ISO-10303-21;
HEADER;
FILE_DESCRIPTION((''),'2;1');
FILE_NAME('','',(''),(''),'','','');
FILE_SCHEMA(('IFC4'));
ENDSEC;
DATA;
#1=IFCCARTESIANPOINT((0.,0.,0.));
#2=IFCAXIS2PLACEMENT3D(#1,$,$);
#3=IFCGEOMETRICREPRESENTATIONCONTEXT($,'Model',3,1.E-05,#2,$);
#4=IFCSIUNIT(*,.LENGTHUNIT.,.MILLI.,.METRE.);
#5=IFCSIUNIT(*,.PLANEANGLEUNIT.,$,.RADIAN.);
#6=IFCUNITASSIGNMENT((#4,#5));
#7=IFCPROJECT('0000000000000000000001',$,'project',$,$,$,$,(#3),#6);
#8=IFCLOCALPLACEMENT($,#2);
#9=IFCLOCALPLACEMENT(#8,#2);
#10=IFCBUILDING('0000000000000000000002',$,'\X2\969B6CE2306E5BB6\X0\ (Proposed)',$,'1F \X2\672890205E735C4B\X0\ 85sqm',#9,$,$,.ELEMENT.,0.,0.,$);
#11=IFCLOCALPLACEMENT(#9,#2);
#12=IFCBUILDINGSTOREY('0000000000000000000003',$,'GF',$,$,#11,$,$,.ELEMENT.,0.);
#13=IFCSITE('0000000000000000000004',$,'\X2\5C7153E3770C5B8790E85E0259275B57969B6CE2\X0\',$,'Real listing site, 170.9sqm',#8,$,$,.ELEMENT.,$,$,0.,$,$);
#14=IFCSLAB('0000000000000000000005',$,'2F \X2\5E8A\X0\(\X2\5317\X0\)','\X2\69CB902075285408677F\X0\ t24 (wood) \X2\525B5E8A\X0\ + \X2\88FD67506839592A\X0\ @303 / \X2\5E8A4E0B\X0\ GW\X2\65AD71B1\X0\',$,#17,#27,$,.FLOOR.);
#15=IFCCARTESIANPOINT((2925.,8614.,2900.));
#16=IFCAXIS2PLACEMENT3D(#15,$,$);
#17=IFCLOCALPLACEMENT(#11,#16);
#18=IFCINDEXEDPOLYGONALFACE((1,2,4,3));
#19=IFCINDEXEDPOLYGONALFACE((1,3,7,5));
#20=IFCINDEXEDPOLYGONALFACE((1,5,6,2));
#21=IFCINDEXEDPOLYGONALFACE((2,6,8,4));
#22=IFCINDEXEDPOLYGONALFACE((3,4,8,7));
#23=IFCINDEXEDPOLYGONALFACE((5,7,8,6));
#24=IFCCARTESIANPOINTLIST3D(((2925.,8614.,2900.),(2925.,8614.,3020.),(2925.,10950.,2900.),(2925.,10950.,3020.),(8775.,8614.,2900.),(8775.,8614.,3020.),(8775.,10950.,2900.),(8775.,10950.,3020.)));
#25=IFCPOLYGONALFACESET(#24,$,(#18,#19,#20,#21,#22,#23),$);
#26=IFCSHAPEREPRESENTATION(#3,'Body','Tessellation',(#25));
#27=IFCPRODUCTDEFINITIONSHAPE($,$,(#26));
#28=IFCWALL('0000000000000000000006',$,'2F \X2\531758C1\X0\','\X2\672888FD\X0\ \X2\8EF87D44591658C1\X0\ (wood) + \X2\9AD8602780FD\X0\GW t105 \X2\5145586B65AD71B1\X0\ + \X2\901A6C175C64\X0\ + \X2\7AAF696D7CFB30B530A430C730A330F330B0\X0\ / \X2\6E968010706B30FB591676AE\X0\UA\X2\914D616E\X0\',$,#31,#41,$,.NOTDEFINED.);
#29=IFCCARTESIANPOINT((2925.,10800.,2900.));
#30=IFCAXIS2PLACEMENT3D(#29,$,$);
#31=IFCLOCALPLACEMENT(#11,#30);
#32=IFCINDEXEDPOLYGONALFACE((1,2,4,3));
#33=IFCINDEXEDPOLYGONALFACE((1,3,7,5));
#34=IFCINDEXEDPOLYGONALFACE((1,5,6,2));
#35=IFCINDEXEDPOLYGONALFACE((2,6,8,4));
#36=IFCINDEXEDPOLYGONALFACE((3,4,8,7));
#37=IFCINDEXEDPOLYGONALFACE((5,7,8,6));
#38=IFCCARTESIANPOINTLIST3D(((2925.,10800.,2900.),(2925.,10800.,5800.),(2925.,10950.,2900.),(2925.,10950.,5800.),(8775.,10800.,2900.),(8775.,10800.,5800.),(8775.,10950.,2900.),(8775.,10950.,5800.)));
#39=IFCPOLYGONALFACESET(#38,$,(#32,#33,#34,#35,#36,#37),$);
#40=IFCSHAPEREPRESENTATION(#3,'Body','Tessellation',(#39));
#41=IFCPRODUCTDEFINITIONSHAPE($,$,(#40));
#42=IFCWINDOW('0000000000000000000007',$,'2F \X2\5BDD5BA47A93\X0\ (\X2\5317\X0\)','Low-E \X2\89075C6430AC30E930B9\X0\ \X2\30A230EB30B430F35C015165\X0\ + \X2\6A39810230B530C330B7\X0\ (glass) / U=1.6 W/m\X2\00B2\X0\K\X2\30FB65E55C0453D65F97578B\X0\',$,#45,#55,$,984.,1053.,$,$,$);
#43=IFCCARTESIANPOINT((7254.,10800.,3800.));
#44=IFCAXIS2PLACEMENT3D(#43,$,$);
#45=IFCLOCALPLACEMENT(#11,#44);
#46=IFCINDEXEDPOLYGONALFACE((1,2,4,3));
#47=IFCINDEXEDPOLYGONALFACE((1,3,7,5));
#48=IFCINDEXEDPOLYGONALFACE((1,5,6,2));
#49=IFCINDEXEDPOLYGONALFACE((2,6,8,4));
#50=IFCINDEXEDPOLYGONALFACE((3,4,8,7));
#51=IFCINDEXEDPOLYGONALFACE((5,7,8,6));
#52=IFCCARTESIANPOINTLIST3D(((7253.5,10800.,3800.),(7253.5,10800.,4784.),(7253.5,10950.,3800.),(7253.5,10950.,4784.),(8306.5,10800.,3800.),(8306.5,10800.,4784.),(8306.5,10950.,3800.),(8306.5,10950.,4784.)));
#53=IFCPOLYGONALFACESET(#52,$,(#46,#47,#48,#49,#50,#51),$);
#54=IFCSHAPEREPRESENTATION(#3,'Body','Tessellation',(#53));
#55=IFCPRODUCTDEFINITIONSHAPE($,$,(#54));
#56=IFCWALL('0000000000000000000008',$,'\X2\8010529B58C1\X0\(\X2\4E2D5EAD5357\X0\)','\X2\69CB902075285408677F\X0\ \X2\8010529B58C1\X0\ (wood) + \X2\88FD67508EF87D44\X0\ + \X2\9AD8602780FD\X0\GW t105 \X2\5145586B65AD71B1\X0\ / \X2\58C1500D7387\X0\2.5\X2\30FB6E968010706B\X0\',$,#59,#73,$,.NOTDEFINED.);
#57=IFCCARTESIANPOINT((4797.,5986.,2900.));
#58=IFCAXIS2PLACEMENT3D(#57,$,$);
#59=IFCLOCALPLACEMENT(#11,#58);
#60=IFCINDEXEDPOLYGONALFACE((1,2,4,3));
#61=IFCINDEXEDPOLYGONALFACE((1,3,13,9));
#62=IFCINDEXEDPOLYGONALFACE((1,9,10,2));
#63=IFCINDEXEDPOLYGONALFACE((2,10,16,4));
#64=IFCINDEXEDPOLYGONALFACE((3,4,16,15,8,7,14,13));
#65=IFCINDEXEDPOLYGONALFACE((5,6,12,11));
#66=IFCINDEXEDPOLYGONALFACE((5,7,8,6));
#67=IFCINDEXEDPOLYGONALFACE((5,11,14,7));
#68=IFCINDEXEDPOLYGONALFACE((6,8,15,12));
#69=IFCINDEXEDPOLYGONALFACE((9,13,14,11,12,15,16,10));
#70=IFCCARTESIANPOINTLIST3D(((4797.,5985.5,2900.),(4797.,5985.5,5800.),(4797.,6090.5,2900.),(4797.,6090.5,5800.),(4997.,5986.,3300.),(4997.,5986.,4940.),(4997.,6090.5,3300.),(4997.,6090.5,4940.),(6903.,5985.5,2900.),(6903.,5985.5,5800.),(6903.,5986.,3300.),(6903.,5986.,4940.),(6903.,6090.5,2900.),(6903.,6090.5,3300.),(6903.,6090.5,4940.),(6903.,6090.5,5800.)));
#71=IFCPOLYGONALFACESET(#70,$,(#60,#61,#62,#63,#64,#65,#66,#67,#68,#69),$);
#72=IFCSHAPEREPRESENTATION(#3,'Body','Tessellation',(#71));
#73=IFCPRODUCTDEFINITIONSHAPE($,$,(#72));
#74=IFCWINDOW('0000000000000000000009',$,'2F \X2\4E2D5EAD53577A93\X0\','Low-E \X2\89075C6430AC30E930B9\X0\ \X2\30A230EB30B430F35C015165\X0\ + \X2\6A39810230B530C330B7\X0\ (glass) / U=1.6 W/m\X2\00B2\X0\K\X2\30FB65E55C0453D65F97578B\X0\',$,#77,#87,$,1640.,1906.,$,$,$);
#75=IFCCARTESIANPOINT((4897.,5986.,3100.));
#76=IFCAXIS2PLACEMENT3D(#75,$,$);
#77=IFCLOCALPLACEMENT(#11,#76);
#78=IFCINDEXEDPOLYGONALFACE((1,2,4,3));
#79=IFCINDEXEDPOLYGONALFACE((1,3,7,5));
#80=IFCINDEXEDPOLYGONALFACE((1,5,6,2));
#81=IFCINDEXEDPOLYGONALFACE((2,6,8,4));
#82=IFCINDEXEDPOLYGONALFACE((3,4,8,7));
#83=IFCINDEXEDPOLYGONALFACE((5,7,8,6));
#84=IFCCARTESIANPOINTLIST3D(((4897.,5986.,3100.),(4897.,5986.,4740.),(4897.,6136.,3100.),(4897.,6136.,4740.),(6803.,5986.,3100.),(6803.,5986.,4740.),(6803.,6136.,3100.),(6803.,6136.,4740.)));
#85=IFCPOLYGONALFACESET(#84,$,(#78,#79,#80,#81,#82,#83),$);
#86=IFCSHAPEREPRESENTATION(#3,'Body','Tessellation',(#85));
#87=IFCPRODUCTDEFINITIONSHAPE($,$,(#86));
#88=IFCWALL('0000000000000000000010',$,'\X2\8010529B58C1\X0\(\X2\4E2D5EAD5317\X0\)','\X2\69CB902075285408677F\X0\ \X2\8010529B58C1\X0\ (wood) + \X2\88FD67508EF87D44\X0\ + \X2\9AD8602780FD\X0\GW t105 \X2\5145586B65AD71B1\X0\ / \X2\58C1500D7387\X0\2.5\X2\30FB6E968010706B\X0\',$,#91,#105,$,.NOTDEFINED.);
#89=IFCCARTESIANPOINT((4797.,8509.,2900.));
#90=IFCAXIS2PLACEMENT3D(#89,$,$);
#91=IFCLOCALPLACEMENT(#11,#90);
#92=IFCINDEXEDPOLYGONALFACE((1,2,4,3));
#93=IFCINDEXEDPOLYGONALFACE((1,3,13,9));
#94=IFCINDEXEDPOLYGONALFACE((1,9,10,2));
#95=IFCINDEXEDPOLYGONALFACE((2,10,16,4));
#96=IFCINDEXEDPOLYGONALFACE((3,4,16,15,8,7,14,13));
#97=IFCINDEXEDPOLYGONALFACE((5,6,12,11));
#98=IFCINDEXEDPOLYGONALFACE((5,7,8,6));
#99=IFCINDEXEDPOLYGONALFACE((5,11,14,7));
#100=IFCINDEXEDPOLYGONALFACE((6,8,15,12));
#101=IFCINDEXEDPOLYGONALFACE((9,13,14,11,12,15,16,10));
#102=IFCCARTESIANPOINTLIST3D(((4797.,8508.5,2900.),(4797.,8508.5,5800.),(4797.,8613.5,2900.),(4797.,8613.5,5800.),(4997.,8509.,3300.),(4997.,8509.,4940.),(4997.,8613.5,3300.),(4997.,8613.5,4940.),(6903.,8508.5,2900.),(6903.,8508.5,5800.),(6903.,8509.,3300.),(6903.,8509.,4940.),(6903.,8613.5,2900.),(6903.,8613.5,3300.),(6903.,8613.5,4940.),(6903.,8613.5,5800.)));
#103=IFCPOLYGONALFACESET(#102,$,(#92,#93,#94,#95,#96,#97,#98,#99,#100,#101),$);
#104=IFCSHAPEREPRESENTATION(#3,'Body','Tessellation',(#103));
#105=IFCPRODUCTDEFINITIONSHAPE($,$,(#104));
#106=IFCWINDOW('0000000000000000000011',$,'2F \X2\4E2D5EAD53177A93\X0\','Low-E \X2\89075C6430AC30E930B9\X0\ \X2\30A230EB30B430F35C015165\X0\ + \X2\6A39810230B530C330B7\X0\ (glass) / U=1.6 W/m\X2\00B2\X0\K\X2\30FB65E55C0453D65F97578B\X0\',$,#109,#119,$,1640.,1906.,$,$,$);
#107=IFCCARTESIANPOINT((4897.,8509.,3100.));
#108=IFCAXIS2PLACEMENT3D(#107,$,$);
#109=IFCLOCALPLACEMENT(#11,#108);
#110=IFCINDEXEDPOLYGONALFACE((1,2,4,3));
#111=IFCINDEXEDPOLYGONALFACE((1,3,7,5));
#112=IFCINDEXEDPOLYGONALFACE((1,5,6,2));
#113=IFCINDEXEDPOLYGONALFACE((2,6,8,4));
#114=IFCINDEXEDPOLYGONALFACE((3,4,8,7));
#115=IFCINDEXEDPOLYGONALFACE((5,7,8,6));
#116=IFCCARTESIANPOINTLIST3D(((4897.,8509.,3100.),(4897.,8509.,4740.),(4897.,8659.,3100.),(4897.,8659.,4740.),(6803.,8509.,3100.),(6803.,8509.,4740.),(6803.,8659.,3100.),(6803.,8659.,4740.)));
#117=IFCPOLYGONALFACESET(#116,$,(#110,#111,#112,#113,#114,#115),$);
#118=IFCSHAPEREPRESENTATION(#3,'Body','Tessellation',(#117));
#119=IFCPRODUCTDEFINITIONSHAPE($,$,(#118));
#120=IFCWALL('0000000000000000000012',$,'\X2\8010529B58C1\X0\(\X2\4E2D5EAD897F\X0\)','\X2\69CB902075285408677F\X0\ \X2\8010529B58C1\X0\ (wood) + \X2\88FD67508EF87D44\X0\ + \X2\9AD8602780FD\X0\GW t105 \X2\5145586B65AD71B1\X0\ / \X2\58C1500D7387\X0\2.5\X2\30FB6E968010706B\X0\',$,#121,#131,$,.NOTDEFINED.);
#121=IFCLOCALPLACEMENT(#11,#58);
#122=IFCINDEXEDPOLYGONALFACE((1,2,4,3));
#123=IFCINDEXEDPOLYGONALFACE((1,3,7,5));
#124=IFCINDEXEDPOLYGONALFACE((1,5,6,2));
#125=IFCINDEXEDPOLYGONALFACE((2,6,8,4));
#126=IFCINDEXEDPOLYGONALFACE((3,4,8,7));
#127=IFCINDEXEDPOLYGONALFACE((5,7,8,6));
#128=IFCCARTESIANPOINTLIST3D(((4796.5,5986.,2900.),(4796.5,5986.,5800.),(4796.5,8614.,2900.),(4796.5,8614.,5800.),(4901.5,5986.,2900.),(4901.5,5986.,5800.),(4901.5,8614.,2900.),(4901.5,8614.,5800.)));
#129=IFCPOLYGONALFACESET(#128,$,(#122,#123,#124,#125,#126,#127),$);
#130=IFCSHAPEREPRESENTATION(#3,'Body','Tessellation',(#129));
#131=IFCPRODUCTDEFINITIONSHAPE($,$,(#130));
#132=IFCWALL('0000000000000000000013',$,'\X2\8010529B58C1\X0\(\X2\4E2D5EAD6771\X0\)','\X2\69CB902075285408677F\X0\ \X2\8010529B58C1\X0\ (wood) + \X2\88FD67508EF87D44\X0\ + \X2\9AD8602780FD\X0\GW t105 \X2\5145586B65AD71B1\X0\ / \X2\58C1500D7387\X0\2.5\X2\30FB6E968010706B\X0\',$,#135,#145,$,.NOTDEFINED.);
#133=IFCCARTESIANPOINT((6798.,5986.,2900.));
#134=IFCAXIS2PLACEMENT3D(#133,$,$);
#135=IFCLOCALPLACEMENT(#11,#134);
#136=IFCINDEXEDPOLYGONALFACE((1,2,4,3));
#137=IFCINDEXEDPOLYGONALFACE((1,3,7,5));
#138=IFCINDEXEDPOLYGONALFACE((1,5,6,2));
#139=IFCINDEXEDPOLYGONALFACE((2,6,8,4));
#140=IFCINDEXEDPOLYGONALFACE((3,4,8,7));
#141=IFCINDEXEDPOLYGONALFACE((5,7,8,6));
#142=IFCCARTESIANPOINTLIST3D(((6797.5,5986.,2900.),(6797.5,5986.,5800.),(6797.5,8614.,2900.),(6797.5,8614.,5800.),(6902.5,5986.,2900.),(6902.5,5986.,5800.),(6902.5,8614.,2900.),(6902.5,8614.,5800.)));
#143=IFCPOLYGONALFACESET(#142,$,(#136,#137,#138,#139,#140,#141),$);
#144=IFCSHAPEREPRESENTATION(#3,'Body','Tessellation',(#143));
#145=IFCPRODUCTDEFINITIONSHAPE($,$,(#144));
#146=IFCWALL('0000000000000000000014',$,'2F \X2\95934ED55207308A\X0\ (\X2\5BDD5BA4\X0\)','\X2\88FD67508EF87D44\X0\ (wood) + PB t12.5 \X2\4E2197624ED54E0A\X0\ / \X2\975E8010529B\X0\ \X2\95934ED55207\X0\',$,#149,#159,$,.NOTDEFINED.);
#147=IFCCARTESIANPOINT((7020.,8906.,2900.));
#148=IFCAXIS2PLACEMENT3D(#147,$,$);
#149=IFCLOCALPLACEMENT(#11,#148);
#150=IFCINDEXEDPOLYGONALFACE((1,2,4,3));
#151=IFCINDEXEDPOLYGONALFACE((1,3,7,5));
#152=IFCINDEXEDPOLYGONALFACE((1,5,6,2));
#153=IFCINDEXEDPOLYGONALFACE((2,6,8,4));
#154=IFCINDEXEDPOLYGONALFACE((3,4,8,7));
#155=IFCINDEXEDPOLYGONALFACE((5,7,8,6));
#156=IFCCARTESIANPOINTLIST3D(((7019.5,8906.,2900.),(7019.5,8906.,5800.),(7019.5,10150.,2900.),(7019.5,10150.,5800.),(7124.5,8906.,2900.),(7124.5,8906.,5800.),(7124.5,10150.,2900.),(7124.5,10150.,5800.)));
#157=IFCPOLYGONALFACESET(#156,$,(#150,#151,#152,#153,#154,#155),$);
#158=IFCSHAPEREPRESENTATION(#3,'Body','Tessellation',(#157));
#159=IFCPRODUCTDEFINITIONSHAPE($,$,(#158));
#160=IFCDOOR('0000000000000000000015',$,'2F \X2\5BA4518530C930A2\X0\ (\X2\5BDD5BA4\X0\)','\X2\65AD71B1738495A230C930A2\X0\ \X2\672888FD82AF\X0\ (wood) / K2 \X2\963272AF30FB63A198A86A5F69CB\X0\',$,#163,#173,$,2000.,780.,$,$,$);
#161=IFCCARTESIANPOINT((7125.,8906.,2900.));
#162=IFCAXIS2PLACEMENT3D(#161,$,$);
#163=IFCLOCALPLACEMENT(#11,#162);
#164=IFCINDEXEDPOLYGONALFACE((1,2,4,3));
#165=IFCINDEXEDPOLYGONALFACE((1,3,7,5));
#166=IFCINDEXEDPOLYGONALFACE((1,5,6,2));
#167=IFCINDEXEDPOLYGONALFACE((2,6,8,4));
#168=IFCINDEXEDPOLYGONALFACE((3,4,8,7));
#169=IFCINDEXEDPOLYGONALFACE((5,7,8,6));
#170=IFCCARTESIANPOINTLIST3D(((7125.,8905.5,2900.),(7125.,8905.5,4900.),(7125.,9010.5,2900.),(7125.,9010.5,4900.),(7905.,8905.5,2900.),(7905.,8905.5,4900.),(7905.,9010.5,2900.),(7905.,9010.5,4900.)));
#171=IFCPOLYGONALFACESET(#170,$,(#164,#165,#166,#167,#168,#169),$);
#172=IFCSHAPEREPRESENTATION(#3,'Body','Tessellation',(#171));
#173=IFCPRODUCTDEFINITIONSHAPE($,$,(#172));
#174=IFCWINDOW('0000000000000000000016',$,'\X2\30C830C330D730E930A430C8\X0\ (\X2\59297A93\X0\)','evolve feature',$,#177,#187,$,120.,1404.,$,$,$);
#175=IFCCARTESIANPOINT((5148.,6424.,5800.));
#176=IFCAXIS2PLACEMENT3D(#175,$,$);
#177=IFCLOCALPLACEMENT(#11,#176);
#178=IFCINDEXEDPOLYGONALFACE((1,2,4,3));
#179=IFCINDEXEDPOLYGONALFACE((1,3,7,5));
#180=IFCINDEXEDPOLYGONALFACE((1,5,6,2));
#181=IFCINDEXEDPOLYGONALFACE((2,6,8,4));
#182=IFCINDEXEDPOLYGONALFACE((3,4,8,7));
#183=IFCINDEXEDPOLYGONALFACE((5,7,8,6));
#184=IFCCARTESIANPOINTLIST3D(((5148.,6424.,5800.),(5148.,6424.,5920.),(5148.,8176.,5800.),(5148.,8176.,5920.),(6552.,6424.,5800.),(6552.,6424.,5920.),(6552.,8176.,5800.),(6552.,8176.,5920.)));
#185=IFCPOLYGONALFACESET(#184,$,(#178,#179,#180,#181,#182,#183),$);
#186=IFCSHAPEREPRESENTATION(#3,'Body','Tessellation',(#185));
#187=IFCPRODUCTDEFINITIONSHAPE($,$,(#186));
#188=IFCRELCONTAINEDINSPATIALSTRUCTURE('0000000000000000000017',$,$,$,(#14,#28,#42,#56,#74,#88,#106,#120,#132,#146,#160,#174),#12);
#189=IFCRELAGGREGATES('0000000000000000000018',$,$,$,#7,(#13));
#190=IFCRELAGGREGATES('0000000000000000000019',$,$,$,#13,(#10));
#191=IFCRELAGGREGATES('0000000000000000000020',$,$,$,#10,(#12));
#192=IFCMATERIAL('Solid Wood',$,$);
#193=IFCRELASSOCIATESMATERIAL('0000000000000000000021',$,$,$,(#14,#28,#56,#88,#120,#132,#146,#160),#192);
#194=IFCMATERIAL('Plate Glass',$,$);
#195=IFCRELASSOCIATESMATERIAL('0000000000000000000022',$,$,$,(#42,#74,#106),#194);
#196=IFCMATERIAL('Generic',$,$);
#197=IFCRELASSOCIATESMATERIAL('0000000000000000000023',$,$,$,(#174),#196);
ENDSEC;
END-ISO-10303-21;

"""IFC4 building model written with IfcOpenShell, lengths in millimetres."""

from ifc_helpers import new_model, si_unit, frame, frame_2d, origin, place, context, project, spatial, rectangle, extrude, material, element, fill, save


model = new_model("IFC4")

# Units and contexts
model_context = context("Model", 3, precision=1e-05, world=origin())
ifc_project = project(units=[si_unit("LENGTHUNIT", "METRE", prefix="MILLI"), si_unit("PLANEANGLEUNIT", "RADIAN")], contexts=[model_context])

# Site, building, storey
site_placement = place(None, origin())
site = spatial("IfcSite", under=ifc_project, at=site_placement, Name="山口県宇部市大字際波", ObjectType="Real listing site, 170.9sqm", CompositionType="ELEMENT", RefElevation=0.0)
building_placement = place(site_placement, origin())
building = spatial("IfcBuilding", under=site, at=building_placement, Name="際波の家 (Proposed)", ObjectType="1F 木造平屋 85sqm", CompositionType="ELEMENT", ElevationOfRefHeight=0.0, ElevationOfTerrain=0.0)
storey_placement = place(building_placement, origin())
storey = spatial("IfcBuildingStorey", under=building, at=storey_placement, Name="GF", CompositionType="ELEMENT", Elevation=0.0)

# Slab
ifc_material_1 = material(Name="Solid Wood")
slab_placement = place(storey_placement, frame((2925.0, 8614.0, 2900.0)))
element("IfcSlab", 1, at=slab_placement, inside=storey, material=ifc_material_1, Name="2F 床(北)", Description="構造用合板 t24 (wood) 剛床 + 製材根太 @303 / 床下 GW断熱", PredefinedType="FLOOR", context=model_context, shape_type="SweptSolid", body=[
    extrude(rectangle(XDim=5850.0, YDim=2336.0, at=frame_2d((2925.0, 1168.0))), frame((2925.0, 8614.0, 2900.0)), (0.0, 0.0, 1.0), 120.0),
])

# Walls, openings, windows
wall_1_placement = place(storey_placement, frame((2925.0, 10800.0, 2900.0)))
wall_1 = element("IfcWall", 2, at=wall_1_placement, inside=storey, material=ifc_material_1, Name="2F 北壁", Description="木製 軸組外壁 (wood) + 高性能GW t105 充填断熱 + 通気層 + 窯業系サイディング / 準耐火・外皮UA配慮", PredefinedType="NOTDEFINED", context=model_context, shape_type="SweptSolid", body=[
    extrude(rectangle(XDim=5850.0, YDim=150.0, at=frame_2d((2925.0, 75.0))), frame((2925.0, 10800.0, 2900.0)), (0.0, 0.0, 1.0), 2900.0),
])
opening_1_placement = place(storey_placement, frame((7254.0, 10800.0, 3800.0)))
opening_1 = element("IfcOpeningElement", 3, at=opening_1_placement, cuts=wall_1, PredefinedType="NOTDEFINED", context=model_context, shape_type="SweptSolid", body=[
    extrude(rectangle(XDim=1053.0, YDim=150.0, at=frame_2d((526.0, 75.0))), frame((7254.0, 10800.0, 3800.0)), (0.0, 0.0, 1.0), 984.0),
])
ifc_material_2 = material(Name="Plate Glass")
window_1_placement = place(storey_placement, frame((7254.0, 10800.0, 3800.0)))
window_1 = element("IfcWindow", 4, at=window_1_placement, inside=storey, material=ifc_material_2, Name="2F 寝室窓 (北)", Description="Low-E 複層ガラス アルゴン封入 + 樹脂サッシ (glass) / U=1.6 W/m²K・日射取得型", OverallHeight=984.0, OverallWidth=1053.0, context=model_context, shape_type="SweptSolid", body=[
    extrude(rectangle(XDim=1053.0, YDim=150.0, at=frame_2d((526.0, 75.0))), frame((7254.0, 10800.0, 3800.0)), (0.0, 0.0, 1.0), 984.0),
])
fill(opening_1, window_1)
wall_2_placement = place(storey_placement, frame((4797.0, 5986.0, 2900.0)))
wall_2 = element("IfcWall", 5, at=wall_2_placement, inside=storey, material=ifc_material_1, Name="耐力壁(中庭南)", Description="構造用合板 耐力壁 (wood) + 製材軸組 + 高性能GW t105 充填断熱 / 壁倍率2.5・準耐火", PredefinedType="NOTDEFINED", context=model_context, shape_type="SweptSolid", body=[
    extrude(rectangle(XDim=2106.0, YDim=105.0, at=frame_2d((1053.0, 52.0))), frame((4797.0, 5986.0, 2900.0)), (0.0, 0.0, 1.0), 2900.0),
])
opening_2_placement = place(storey_placement, frame((4897.0, 5986.0, 3100.0)))
opening_2 = element("IfcOpeningElement", 6, at=opening_2_placement, cuts=wall_2, PredefinedType="NOTDEFINED", context=model_context, shape_type="SweptSolid", body=[
    extrude(rectangle(XDim=1906.0, YDim=150.0, at=frame_2d((953.0, 75.0))), frame((4897.0, 5986.0, 3100.0)), (0.0, 0.0, 1.0), 1640.0),
])
window_2_placement = place(storey_placement, frame((4897.0, 5986.0, 3100.0)))
window_2 = element("IfcWindow", 7, at=window_2_placement, inside=storey, material=ifc_material_2, Name="2F 中庭南窓", Description="Low-E 複層ガラス アルゴン封入 + 樹脂サッシ (glass) / U=1.6 W/m²K・日射取得型", OverallHeight=1640.0, OverallWidth=1906.0, context=model_context, shape_type="SweptSolid", body=[
    extrude(rectangle(XDim=1906.0, YDim=150.0, at=frame_2d((953.0, 75.0))), frame((4897.0, 5986.0, 3100.0)), (0.0, 0.0, 1.0), 1640.0),
])
fill(opening_2, window_2)
wall_3_placement = place(storey_placement, frame((4797.0, 8509.0, 2900.0)))
wall_3 = element("IfcWall", 8, at=wall_3_placement, inside=storey, material=ifc_material_1, Name="耐力壁(中庭北)", Description="構造用合板 耐力壁 (wood) + 製材軸組 + 高性能GW t105 充填断熱 / 壁倍率2.5・準耐火", PredefinedType="NOTDEFINED", context=model_context, shape_type="SweptSolid", body=[
    extrude(rectangle(XDim=2106.0, YDim=105.0, at=frame_2d((1053.0, 52.0))), frame((4797.0, 8509.0, 2900.0)), (0.0, 0.0, 1.0), 2900.0),
])
opening_3_placement = place(storey_placement, frame((4897.0, 8509.0, 3100.0)))
opening_3 = element("IfcOpeningElement", 9, at=opening_3_placement, cuts=wall_3, PredefinedType="NOTDEFINED", context=model_context, shape_type="SweptSolid", body=[
    extrude(rectangle(XDim=1906.0, YDim=150.0, at=frame_2d((953.0, 75.0))), frame((4897.0, 8509.0, 3100.0)), (0.0, 0.0, 1.0), 1640.0),
])
window_3_placement = place(storey_placement, frame((4897.0, 8509.0, 3100.0)))
window_3 = element("IfcWindow", 10, at=window_3_placement, inside=storey, material=ifc_material_2, Name="2F 中庭北窓", Description="Low-E 複層ガラス アルゴン封入 + 樹脂サッシ (glass) / U=1.6 W/m²K・日射取得型", OverallHeight=1640.0, OverallWidth=1906.0, context=model_context, shape_type="SweptSolid", body=[
    extrude(rectangle(XDim=1906.0, YDim=150.0, at=frame_2d((953.0, 75.0))), frame((4897.0, 8509.0, 3100.0)), (0.0, 0.0, 1.0), 1640.0),
])
fill(opening_3, window_3)

# Walls
wall_4_placement = place(storey_placement, frame((4797.0, 5986.0, 2900.0)))
element("IfcWall", 11, at=wall_4_placement, inside=storey, material=ifc_material_1, Name="耐力壁(中庭西)", Description="構造用合板 耐力壁 (wood) + 製材軸組 + 高性能GW t105 充填断熱 / 壁倍率2.5・準耐火", PredefinedType="NOTDEFINED", context=model_context, shape_type="SweptSolid", body=[
    extrude(rectangle(XDim=105.0, YDim=2628.0, at=frame_2d((52.0, 1314.0))), frame((4797.0, 5986.0, 2900.0)), (0.0, 0.0, 1.0), 2900.0),
])
wall_5_placement = place(storey_placement, frame((6798.0, 5986.0, 2900.0)))
element("IfcWall", 12, at=wall_5_placement, inside=storey, material=ifc_material_1, Name="耐力壁(中庭東)", Description="構造用合板 耐力壁 (wood) + 製材軸組 + 高性能GW t105 充填断熱 / 壁倍率2.5・準耐火", PredefinedType="NOTDEFINED", context=model_context, shape_type="SweptSolid", body=[
    extrude(rectangle(XDim=105.0, YDim=2628.0, at=frame_2d((52.0, 1314.0))), frame((6798.0, 5986.0, 2900.0)), (0.0, 0.0, 1.0), 2900.0),
])
wall_6_placement = place(storey_placement, frame((7020.0, 8906.0, 2900.0)))
element("IfcWall", 13, at=wall_6_placement, inside=storey, material=ifc_material_1, Name="2F 間仕切り (寝室)", Description="製材軸組 (wood) + PB t12.5 両面仕上 / 非耐力 間仕切", PredefinedType="NOTDEFINED", context=model_context, shape_type="SweptSolid", body=[
    extrude(rectangle(XDim=105.0, YDim=1244.0, at=frame_2d((52.0, 622.0))), frame((7020.0, 8906.0, 2900.0)), (0.0, 0.0, 1.0), 2900.0),
])

# Door
door_placement = place(storey_placement, frame((7125.0, 8906.0, 2900.0)))
element("IfcDoor", 14, at=door_placement, inside=storey, material=ifc_material_1, Name="2F 室内ドア (寝室)", Description="断熱玄関ドア 木製芯 (wood) / K2 防犯・採風機構", OverallHeight=2000.0, OverallWidth=780.0, context=model_context, shape_type="SweptSolid", body=[
    extrude(rectangle(XDim=780.0, YDim=105.0, at=frame_2d((390.0, 52.0))), frame((7125.0, 8906.0, 2900.0)), (0.0, 0.0, 1.0), 2000.0),
])

# Window
ifc_material_3 = material(Name="Generic")
window_4_placement = place(storey_placement, frame((5148.0, 6424.0, 5800.0)))
element("IfcWindow", 15, at=window_4_placement, inside=storey, material=ifc_material_3, Name="トップライト (天窓)", Description="evolve feature", OverallHeight=120.0, OverallWidth=1404.0, context=model_context, shape_type="SweptSolid", body=[
    extrude(rectangle(XDim=1404.0, YDim=1752.0, at=frame_2d((702.0, 876.0))), frame((5148.0, 6424.0, 5800.0)), (0.0, 0.0, 1.0), 120.0),
])

save(model, "model.ifc")
